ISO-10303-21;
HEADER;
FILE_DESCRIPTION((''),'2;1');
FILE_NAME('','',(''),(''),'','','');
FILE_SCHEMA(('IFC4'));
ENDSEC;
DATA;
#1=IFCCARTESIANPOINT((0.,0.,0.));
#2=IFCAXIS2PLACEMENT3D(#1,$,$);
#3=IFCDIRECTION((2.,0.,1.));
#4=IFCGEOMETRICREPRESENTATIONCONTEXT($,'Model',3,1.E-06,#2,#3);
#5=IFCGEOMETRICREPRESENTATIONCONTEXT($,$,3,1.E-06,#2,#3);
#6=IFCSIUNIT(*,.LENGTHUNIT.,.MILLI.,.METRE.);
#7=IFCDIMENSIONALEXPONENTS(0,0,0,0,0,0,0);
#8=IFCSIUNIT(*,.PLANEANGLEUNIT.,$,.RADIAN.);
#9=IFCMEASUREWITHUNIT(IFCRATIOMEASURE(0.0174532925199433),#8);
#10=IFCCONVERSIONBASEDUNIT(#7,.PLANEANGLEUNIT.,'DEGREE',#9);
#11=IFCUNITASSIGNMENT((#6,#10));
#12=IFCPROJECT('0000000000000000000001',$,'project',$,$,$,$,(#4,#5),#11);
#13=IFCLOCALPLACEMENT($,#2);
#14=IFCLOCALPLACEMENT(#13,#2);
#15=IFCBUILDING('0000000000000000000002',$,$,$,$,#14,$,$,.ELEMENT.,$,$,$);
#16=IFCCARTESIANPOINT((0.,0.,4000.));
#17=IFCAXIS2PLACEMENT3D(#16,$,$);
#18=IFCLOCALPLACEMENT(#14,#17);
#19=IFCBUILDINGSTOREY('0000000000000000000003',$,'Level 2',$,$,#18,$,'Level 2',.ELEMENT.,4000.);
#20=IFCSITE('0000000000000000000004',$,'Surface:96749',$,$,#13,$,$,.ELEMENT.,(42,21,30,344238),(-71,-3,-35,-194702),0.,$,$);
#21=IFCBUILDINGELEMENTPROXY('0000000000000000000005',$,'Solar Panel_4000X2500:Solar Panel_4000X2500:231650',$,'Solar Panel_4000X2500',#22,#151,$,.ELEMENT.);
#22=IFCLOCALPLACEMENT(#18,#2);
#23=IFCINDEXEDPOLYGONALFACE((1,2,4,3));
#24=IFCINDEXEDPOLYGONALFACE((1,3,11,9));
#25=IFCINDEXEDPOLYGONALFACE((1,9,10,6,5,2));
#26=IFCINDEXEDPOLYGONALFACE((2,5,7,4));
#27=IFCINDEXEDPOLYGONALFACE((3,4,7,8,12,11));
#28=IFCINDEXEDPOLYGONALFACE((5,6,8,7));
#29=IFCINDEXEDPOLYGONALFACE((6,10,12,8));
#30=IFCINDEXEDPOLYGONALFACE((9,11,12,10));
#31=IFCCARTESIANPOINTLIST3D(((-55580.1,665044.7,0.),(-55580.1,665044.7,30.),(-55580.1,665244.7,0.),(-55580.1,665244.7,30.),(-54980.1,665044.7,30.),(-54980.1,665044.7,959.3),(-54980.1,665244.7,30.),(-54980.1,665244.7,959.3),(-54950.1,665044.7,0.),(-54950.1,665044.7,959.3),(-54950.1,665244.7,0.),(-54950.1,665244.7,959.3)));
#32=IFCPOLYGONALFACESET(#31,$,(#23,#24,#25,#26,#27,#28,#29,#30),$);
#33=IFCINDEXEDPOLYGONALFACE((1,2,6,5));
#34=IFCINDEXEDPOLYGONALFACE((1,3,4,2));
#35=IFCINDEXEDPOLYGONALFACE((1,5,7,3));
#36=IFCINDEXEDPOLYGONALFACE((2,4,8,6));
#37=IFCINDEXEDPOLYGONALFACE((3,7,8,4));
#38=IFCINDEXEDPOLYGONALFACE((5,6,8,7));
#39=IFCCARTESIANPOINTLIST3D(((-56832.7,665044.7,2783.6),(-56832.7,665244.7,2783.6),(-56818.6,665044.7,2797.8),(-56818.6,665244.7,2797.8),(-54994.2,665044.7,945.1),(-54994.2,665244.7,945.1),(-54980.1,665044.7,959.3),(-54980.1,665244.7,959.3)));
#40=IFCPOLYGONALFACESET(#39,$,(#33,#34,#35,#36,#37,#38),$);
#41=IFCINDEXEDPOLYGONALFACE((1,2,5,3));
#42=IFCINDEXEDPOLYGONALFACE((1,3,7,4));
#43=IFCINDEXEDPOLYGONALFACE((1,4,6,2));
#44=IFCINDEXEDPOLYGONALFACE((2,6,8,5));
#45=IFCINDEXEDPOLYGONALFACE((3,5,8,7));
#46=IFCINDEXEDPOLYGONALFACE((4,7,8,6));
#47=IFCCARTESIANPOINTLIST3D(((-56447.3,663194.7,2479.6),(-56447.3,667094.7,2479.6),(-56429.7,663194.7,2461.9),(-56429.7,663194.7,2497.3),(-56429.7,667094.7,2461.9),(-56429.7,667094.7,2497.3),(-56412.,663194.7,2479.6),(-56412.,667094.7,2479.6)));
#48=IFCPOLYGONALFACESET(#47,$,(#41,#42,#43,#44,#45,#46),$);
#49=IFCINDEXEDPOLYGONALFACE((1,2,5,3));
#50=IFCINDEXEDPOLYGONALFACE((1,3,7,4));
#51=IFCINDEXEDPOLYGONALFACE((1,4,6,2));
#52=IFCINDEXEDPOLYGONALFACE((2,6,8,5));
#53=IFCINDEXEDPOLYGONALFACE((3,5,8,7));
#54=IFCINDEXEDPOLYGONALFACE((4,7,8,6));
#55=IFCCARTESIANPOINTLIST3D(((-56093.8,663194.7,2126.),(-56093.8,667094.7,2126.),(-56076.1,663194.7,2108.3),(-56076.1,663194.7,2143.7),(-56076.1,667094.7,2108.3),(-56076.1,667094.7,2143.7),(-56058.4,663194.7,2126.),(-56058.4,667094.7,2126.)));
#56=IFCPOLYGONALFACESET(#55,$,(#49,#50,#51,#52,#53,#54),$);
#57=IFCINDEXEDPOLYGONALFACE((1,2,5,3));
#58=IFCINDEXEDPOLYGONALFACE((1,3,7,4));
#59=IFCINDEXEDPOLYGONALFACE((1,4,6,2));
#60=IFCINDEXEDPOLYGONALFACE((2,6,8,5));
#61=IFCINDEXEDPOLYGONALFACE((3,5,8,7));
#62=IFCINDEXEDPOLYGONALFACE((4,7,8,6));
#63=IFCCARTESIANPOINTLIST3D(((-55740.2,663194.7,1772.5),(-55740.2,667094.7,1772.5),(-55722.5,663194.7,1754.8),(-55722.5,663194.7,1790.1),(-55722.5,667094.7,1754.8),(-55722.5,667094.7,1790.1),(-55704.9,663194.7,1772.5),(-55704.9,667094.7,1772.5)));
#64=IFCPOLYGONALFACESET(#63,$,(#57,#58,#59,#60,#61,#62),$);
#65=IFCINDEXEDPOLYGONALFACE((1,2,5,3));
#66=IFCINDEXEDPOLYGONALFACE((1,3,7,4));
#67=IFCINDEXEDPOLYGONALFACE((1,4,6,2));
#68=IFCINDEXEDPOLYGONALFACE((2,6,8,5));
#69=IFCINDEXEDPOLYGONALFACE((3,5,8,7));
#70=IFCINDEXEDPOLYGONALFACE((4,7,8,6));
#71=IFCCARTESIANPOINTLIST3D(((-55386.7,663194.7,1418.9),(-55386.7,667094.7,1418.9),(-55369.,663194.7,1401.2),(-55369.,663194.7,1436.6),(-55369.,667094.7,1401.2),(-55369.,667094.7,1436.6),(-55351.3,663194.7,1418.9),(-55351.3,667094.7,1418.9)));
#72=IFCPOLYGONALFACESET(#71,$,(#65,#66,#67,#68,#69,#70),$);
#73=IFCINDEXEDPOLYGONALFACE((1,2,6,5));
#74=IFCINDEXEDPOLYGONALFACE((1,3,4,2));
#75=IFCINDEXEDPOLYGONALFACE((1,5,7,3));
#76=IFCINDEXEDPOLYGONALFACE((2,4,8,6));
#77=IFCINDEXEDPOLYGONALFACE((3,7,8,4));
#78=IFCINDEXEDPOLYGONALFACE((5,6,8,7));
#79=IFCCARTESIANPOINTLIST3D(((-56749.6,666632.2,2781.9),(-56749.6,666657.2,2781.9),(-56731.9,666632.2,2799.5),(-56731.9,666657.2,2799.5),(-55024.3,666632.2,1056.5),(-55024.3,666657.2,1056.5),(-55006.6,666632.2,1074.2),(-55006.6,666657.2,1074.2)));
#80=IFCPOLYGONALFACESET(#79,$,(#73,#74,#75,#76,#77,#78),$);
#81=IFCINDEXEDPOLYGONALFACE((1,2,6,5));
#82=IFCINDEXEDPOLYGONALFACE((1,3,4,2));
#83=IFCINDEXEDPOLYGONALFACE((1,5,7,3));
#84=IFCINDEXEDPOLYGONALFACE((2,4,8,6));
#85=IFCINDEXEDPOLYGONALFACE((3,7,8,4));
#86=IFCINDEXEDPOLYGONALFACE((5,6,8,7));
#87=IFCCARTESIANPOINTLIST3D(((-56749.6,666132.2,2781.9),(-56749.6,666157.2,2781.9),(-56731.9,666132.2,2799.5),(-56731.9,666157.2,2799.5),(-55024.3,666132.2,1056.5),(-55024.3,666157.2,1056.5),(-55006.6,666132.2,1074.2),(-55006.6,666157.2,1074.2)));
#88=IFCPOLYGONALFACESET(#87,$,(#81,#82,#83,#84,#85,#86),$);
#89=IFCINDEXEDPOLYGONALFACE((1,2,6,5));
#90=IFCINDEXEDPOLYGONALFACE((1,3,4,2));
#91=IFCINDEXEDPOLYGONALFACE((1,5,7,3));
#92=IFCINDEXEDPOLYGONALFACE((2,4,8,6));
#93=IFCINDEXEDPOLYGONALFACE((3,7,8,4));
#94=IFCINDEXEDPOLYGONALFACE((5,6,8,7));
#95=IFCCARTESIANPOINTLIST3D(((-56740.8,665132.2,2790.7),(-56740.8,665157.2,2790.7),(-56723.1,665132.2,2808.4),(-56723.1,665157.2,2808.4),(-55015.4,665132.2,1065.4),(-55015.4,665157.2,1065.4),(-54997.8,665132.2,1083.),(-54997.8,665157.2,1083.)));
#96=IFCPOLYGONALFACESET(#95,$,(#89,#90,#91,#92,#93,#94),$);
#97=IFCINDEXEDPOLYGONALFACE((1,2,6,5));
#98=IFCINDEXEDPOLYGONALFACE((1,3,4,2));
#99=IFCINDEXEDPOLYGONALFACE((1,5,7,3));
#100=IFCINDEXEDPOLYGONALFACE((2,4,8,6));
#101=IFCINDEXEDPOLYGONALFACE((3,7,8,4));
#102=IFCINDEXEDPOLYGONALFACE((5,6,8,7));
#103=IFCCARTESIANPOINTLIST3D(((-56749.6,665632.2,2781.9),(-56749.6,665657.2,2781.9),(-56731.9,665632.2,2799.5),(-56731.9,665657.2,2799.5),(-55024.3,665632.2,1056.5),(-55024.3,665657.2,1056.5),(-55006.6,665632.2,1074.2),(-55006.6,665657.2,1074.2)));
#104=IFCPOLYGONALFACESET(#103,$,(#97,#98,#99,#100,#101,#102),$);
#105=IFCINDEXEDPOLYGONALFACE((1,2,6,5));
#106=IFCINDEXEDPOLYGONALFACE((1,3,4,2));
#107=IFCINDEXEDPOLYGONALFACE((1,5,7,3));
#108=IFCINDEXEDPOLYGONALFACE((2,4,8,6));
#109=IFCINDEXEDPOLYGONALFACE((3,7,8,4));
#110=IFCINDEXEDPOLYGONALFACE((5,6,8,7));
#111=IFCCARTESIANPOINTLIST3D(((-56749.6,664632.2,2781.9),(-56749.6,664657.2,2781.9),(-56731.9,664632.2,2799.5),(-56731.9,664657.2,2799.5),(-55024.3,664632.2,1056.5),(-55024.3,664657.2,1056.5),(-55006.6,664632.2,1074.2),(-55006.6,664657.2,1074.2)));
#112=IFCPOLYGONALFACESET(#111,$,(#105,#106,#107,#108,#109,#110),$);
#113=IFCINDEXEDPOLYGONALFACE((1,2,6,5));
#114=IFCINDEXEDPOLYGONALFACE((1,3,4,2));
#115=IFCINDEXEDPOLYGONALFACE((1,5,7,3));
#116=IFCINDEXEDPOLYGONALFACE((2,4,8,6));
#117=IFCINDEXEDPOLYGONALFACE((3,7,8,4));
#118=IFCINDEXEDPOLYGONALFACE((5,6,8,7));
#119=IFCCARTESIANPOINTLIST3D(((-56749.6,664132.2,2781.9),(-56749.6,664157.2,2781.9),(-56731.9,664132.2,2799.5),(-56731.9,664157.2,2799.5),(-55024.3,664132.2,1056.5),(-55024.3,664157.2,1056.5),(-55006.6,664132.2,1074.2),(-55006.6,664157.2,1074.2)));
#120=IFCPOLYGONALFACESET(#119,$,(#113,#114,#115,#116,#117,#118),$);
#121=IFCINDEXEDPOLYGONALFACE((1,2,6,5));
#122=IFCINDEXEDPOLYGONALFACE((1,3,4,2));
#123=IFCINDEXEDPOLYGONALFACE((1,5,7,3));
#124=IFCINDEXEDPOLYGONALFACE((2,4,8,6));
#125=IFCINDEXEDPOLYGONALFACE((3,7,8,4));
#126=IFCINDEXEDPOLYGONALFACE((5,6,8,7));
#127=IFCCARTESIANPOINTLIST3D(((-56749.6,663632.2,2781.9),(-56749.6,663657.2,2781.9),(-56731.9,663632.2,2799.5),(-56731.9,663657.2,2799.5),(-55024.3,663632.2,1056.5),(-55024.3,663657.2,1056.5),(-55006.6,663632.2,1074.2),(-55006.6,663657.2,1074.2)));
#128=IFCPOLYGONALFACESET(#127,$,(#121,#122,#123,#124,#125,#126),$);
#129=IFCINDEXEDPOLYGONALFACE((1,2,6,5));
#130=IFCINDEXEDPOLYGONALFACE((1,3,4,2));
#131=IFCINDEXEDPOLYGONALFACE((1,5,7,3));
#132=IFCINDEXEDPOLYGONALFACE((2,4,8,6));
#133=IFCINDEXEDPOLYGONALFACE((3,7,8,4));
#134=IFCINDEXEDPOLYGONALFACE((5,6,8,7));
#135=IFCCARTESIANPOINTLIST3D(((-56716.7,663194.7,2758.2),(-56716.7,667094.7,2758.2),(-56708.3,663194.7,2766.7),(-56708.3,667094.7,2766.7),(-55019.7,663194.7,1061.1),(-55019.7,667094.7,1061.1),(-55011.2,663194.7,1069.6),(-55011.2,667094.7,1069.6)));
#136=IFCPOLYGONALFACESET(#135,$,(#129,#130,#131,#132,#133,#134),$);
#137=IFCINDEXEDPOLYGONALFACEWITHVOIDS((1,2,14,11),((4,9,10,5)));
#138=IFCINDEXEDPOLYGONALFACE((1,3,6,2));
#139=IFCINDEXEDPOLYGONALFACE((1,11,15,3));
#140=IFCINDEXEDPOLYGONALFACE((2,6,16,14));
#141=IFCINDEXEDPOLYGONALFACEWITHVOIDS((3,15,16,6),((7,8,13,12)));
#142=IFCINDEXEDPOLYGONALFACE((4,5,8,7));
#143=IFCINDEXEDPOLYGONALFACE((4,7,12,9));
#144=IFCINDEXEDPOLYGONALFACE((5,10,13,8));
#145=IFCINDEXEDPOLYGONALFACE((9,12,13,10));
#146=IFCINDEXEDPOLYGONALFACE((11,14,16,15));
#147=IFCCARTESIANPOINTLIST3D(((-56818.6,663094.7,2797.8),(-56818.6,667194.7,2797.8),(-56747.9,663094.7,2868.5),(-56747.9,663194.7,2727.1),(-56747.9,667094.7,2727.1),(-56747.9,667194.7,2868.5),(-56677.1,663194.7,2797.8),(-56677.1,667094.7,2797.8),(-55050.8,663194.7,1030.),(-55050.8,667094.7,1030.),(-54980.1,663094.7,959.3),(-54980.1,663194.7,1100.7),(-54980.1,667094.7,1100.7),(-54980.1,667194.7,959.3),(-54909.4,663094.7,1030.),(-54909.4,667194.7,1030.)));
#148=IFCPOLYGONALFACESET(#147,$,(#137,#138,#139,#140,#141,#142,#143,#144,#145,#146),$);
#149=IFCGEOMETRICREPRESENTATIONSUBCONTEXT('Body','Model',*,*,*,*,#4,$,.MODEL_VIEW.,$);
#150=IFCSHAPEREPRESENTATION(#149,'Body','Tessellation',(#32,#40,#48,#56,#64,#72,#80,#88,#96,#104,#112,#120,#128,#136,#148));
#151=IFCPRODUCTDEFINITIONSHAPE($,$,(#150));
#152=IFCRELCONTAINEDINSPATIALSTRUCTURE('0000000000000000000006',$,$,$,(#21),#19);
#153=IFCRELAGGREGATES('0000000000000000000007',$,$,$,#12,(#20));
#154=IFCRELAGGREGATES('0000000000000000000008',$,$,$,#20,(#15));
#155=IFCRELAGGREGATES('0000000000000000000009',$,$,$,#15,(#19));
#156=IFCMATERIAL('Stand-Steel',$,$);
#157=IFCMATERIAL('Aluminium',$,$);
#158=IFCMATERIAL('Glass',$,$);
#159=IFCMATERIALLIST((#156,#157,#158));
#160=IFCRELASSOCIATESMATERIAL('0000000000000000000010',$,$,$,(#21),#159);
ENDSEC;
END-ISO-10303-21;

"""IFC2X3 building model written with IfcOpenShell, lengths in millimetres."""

from ifc_helpers import new_model, entity, si_unit, converted_unit, direction, frame, frame_2d, origin, origin_2d_with_axis, place, context, subcontext, project, spatial, polyline, rectangle, outline, extrude, source, transform, mapped, material, material_list, element, save


model = new_model("IFC2X3")

# Units and contexts
model_context = context("Model", 3, precision=1e-06, world=origin(), true_north=direction((2.0, 0.0, 1.0)))
context_of_model = context(None, 3, precision=1e-06, world=origin(), true_north=direction((2.0, 0.0, 1.0)))
body_context = subcontext(model_context, "Body", "Model", "MODEL_VIEW")
ifc_project = project(units=[si_unit("LENGTHUNIT", "METRE", prefix="MILLI"), converted_unit("PLANEANGLEUNIT", "DEGREE", entity("IfcRatioMeasure", 0.0174532925199433), si_unit("PLANEANGLEUNIT", "RADIAN"), dimensions=[0, 0, 0, 0, 0, 0, 0])], contexts=[model_context, context_of_model])

# Site, building, storey
site_placement = place(None, origin())
site = spatial("IfcSite", under=ifc_project, at=site_placement, Name="Surface:96749", CompositionType="ELEMENT", RefLatitude=(42, 21, 30, 344238), RefLongitude=(-71, -3, -35, -194702), RefElevation=0.0)
building_placement = place(site_placement, origin())
building = spatial("IfcBuilding", under=site, at=building_placement, CompositionType="ELEMENT")
storey_placement = place(building_placement, frame((0.0, 0.0, 4000.0)))
storey = spatial("IfcBuildingStorey", under=building, at=storey_placement, Name="Level 2", LongName="Level 2", CompositionType="ELEMENT", Elevation=4000.0)

# Building element proxy
ifc_material_1 = material(Name="Stand-Steel")
ifc_material_2 = material(Name="Aluminium")
ifc_material_3 = material(Name="Glass")
shared_shape = source(origin(), body_context, "Body", "SweptSolid", [
    extrude(outline(polyline([(-629.5, -220.0), (329.8, -220.0), (329.8, 410.0), (299.8, 410.0), (299.8, -190.0), (-629.5, -190.0), (-629.5, -220.0)])), frame((-190.0, -100.0, 299.8), z_axis=(0.0, 1.0, 0.0), x_axis=(0.0, 0.0, -1.0)), (0.0, 0.0, 1.0), 200.0),
    extrude(rectangle(XDim=20.0, YDim=200.0, at=frame_2d((0.0, 0.0), x_axis=(0.0, 1.0))), frame((-7.1, 0.0, 922.2), z_axis=(-0.707107, 0.0, 0.707107), x_axis=(0.0, 1.0, 0.0)), (0.0, 0.0, 1.0), 2600.0),
    extrude(rectangle(XDim=25.0, YDim=25.0, at=frame_2d((0.0, 0.0), x_axis=(1.0, 0.0))), frame((-1449.6, -1950.0, 2449.6), z_axis=(0.0, 1.0, 0.0), x_axis=(-0.707107, 0.0, -0.707107)), (0.0, 0.0, 1.0), 3900.0),
    extrude(rectangle(XDim=25.0, YDim=25.0, at=origin_2d_with_axis()), frame((-1096.0, -1950.0, 2096.0), z_axis=(0.0, 1.0, 0.0), x_axis=(-0.707107, 0.0, -0.707107)), (0.0, 0.0, 1.0), 3900.0),
    extrude(rectangle(XDim=25.0, YDim=25.0, at=origin_2d_with_axis()), frame((-742.5, -1950.0, 1742.5), z_axis=(0.0, 1.0, 0.0), x_axis=(-0.707107, 0.0, -0.707107)), (0.0, 0.0, 1.0), 3900.0),
    extrude(rectangle(XDim=25.0, YDim=25.0, at=frame_2d((0.0, 0.0), x_axis=(1.0, 0.0))), frame((-388.9, -1950.0, 1388.9), z_axis=(0.0, 1.0, 0.0), x_axis=(-0.707107, 0.0, -0.707107)), (0.0, 0.0, 1.0), 3900.0),
    extrude(rectangle(XDim=25.0, YDim=25.0, at=frame_2d((0.0, 0.0), x_axis=(0.0, 1.0))), frame((-35.4, 1500.0, 1035.4), z_axis=(-0.707107, 0.0, 0.707107), x_axis=(0.0, 1.0, 0.0)), (0.0, 0.0, 1.0), 2440.0),
    extrude(rectangle(XDim=25.0, YDim=25.0, at=frame_2d((0.0, 0.0), x_axis=(0.0, 1.0))), frame((-35.4, 1000.0, 1035.4), z_axis=(-0.707107, 0.0, 0.707107), x_axis=(0.0, 1.0, 0.0)), (0.0, 0.0, 1.0), 2440.0),
    extrude(rectangle(XDim=25.0, YDim=25.0, at=frame_2d((0.0, 0.0), x_axis=(0.0, 1.0))), frame((-26.5, 0.0, 1044.2), z_axis=(-0.707107, 0.0, 0.707107), x_axis=(0.0, -1.0, 0.0)), (0.0, 0.0, 1.0), 2440.0),
    extrude(rectangle(XDim=25.0, YDim=25.0, at=frame_2d((0.0, 0.0), x_axis=(0.0, 1.0))), frame((-35.4, 500.0, 1035.4), z_axis=(-0.707107, 0.0, 0.707107), x_axis=(0.0, 1.0, 0.0)), (0.0, 0.0, 1.0), 2440.0),
    extrude(rectangle(XDim=25.0, YDim=25.0, at=frame_2d((0.0, 0.0), x_axis=(0.0, 1.0))), frame((-35.4, -500.0, 1035.4), z_axis=(-0.707107, 0.0, 0.707107), x_axis=(0.0, 1.0, 0.0)), (0.0, 0.0, 1.0), 2440.0),
    extrude(rectangle(XDim=25.0, YDim=25.0, at=frame_2d((0.0, 0.0), x_axis=(0.0, 1.0))), frame((-35.4, -1000.0, 1035.4), z_axis=(-0.707107, 0.0, 0.707107), x_axis=(0.0, 1.0, 0.0)), (0.0, 0.0, 1.0), 2440.0),
    extrude(rectangle(XDim=25.0, YDim=25.0, at=frame_2d((0.0, 0.0), x_axis=(0.0, 1.0))), frame((-35.4, -1500.0, 1035.4), z_axis=(-0.707107, 0.0, 0.707107), x_axis=(0.0, 1.0, 0.0)), (0.0, 0.0, 1.0), 2440.0),
    extrude(rectangle(XDim=2400.0, YDim=12.0, at=frame_2d((0.0, 0.0), x_axis=(1.0, 0.0))), frame((-883.9, -1950.0, 1883.9), z_axis=(0.0, 1.0, 0.0), x_axis=(0.707107, 0.0, -0.707107)), (0.0, 0.0, 1.0), 3900.0),
    extrude(outline(polyline([(-2050.0, -1300.0), (2050.0, -1300.0), (2050.0, 1300.0), (-2050.0, 1300.0), (-2050.0, -1300.0)]), holes=[polyline([(1950.0, -1200.0), (-1950.0, -1200.0), (-1950.0, 1200.0), (1950.0, 1200.0), (1950.0, -1200.0)])]), frame((-919.2, 0.0, 1848.5), z_axis=(0.707107, 0.0, 0.707107), x_axis=(0.0, 1.0, 0.0)), (0.0, 0.0, 1.0), 100.0),
])
ifc_material_list_1 = material_list([ifc_material_1, ifc_material_2, ifc_material_3])
proxy_1_placement = place(storey_placement, frame((-54980.1, 665144.7, 30.0)))
element("IfcBuildingElementProxy", 1, at=proxy_1_placement, inside=storey, material=ifc_material_list_1, Name="Solar Panel_4000X2500:Solar Panel_4000X2500:231650", ObjectType="Solar Panel_4000X2500", CompositionType="ELEMENT", context=body_context, shape_type="MappedRepresentation", body=[
    mapped(shared_shape, transform((0.0, 0.0, 0.0), scale=1.0)),
])

save(model, "model.ifc")
